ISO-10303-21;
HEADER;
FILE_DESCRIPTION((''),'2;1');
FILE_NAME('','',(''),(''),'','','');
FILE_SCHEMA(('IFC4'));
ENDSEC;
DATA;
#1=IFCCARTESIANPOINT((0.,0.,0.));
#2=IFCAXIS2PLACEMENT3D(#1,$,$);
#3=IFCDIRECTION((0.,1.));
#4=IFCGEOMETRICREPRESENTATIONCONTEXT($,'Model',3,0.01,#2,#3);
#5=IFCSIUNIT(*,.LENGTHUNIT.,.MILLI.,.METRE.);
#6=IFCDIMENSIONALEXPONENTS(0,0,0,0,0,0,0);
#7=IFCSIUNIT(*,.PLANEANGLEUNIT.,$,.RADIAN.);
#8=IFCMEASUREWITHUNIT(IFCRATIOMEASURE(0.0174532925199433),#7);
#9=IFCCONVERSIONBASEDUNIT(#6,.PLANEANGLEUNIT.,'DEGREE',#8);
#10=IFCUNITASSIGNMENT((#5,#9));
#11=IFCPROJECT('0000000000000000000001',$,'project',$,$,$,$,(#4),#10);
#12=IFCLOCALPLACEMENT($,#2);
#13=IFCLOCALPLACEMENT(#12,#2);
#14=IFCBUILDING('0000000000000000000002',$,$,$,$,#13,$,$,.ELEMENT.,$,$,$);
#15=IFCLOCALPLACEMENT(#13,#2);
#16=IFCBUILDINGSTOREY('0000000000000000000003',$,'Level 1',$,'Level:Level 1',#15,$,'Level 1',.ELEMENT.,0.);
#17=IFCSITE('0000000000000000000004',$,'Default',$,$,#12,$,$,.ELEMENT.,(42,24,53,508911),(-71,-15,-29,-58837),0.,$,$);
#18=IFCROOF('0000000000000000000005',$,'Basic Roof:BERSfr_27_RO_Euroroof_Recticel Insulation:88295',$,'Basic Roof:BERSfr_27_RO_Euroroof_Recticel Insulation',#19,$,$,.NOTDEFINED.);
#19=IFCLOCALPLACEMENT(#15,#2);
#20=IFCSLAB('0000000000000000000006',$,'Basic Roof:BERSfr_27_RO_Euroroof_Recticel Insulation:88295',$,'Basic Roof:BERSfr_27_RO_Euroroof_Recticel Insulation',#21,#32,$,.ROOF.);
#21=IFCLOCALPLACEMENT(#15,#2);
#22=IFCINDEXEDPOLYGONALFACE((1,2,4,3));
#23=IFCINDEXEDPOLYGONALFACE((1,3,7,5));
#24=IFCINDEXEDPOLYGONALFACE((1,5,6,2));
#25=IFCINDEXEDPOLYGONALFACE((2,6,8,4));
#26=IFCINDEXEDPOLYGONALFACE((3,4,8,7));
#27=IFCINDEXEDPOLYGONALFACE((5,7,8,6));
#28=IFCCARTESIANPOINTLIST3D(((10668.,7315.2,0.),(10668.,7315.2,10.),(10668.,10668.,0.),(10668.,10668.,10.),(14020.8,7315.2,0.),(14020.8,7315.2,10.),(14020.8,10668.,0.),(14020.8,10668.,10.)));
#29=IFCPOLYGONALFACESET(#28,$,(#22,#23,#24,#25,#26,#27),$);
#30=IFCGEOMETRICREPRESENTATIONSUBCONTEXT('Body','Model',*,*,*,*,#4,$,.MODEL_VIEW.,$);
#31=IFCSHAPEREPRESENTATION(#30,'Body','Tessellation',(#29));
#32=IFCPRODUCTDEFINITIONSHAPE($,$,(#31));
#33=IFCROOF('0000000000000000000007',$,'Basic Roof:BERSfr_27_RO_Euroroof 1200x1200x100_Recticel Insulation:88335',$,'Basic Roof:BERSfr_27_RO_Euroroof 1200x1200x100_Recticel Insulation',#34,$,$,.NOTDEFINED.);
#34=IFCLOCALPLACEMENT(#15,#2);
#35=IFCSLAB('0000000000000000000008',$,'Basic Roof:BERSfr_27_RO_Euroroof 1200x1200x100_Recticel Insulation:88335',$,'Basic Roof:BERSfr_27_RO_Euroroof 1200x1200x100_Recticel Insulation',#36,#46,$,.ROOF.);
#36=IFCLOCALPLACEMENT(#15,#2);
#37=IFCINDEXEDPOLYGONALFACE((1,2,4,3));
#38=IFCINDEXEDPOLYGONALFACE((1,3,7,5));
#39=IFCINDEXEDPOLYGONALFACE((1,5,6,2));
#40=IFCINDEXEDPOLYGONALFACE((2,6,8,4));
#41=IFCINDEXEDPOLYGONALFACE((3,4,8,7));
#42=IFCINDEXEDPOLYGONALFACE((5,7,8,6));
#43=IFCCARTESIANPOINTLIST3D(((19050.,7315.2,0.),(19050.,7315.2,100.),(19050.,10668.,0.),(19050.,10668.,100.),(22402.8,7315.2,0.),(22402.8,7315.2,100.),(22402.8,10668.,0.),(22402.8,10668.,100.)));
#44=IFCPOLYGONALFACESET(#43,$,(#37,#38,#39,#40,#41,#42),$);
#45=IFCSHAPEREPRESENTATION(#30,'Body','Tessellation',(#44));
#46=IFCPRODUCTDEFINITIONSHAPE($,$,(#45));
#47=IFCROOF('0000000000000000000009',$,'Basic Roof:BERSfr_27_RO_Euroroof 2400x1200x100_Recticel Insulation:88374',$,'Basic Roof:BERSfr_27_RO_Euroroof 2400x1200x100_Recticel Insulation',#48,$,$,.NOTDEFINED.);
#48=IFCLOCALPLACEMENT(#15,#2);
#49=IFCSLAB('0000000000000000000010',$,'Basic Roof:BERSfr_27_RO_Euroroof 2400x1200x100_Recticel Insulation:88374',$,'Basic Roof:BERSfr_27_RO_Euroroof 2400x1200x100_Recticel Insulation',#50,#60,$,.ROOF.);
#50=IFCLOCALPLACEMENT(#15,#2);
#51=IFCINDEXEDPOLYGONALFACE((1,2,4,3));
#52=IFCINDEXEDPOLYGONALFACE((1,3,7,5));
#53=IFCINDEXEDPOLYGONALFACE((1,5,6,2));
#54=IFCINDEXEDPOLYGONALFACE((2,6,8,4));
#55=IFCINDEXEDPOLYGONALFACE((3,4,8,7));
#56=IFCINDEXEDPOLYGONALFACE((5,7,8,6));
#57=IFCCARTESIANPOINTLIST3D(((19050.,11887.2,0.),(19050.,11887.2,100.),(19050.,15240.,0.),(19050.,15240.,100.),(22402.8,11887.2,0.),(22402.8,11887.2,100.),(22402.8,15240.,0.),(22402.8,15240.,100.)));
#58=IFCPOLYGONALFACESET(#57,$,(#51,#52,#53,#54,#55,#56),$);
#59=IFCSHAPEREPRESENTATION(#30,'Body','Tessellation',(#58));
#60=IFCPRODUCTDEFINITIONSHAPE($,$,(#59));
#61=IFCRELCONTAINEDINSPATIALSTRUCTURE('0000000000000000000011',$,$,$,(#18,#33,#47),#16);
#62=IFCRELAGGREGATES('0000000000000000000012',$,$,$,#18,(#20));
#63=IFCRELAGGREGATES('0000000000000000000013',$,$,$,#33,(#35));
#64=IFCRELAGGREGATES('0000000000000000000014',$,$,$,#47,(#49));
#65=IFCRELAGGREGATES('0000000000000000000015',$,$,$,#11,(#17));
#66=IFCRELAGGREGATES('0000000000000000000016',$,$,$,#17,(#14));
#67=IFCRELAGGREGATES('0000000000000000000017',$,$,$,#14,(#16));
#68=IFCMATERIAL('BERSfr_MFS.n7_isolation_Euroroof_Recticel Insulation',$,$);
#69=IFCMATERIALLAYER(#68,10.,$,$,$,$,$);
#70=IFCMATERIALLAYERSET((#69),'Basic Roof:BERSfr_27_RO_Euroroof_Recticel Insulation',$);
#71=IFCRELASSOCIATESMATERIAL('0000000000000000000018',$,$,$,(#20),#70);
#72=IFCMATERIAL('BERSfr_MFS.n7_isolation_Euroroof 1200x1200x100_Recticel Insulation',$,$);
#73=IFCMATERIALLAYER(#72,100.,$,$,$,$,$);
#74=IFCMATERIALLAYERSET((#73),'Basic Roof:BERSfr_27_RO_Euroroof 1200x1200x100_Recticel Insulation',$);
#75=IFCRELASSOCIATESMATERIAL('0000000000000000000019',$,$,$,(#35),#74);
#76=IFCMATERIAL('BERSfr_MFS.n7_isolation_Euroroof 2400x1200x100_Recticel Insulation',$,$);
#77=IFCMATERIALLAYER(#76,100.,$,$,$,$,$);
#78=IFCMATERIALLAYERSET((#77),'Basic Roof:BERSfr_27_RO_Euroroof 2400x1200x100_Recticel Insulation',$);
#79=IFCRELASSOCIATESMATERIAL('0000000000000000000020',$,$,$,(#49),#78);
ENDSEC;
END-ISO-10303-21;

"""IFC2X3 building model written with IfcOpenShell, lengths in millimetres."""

from ifc_helpers import new_model, entity, si_unit, converted_unit, direction, frame, frame_2d, origin, place, context, subcontext, project, spatial, rectangle, extrude, material, layer, layer_set, element, aggregate, save


model = new_model("IFC2X3")

# Units and contexts
model_context = context("Model", 3, precision=0.01, world=origin(), true_north=direction((0.0, 1.0)))
body_context = subcontext(model_context, "Body", "Model", "MODEL_VIEW")
ifc_project = project(units=[si_unit("LENGTHUNIT", "METRE", prefix="MILLI"), converted_unit("PLANEANGLEUNIT", "DEGREE", entity("IfcRatioMeasure", 0.0174532925199433), si_unit("PLANEANGLEUNIT", "RADIAN"), dimensions=[0, 0, 0, 0, 0, 0, 0])], contexts=[model_context])

# Site, building, storey
site_placement = place(None, origin())
site = spatial("IfcSite", under=ifc_project, at=site_placement, Name="Default", CompositionType="ELEMENT", RefLatitude=(42, 24, 53, 508911), RefLongitude=(-71, -15, -29, -58837), RefElevation=0.0)
building_placement = place(site_placement, origin())
building = spatial("IfcBuilding", under=site, at=building_placement, CompositionType="ELEMENT")
storey_placement = place(building_placement, origin())
storey = spatial("IfcBuildingStorey", under=building, at=storey_placement, Name="Level 1", ObjectType="Level:Level 1", LongName="Level 1", CompositionType="ELEMENT", Elevation=0.0)

# Roofs, slabs
roof_1_placement = place(storey_placement, frame((10668.0, 7315.2, 0.0)))
roof_1 = element("IfcRoof", 1, at=roof_1_placement, inside=storey, Name="Basic Roof:BERSfr_27_RO_Euroroof_Recticel Insulation:88295", ObjectType="Basic Roof:BERSfr_27_RO_Euroroof_Recticel Insulation", ShapeType="NOTDEFINED")
ifc_material_1 = material(Name="BERSfr_MFS.n7_isolation_Euroroof_Recticel Insulation")
ifc_layer_1 = layer(ifc_material_1, 10.0)
ifc_layer_set_1 = layer_set([ifc_layer_1], Name="Basic Roof:BERSfr_27_RO_Euroroof_Recticel Insulation")
slab_1_placement = place(roof_1_placement, origin())
slab_1 = element("IfcSlab", 2, at=slab_1_placement, material=ifc_layer_set_1, Name="Basic Roof:BERSfr_27_RO_Euroroof_Recticel Insulation:88295", ObjectType="Basic Roof:BERSfr_27_RO_Euroroof_Recticel Insulation", PredefinedType="ROOF", context=body_context, shape_type="SweptSolid", body=[
    extrude(rectangle(XDim=3352.8, YDim=3352.8, at=frame_2d((0.0, 0.0), x_axis=(-1.0, 0.0))), frame((1676.4, 1676.4, 0.0)), (0.0, 0.0, 1.0), 10.0),
])
aggregate(roof_1, [slab_1])
roof_2_placement = place(storey_placement, frame((19050.0, 7315.2, 0.0)))
roof_2 = element("IfcRoof", 3, at=roof_2_placement, inside=storey, Name="Basic Roof:BERSfr_27_RO_Euroroof 1200x1200x100_Recticel Insulation:88335", ObjectType="Basic Roof:BERSfr_27_RO_Euroroof 1200x1200x100_Recticel Insulation", ShapeType="NOTDEFINED")
ifc_material_2 = material(Name="BERSfr_MFS.n7_isolation_Euroroof 1200x1200x100_Recticel Insulation")
ifc_layer_2 = layer(ifc_material_2, 100.0)
ifc_layer_set_2 = layer_set([ifc_layer_2], Name="Basic Roof:BERSfr_27_RO_Euroroof 1200x1200x100_Recticel Insulation")
slab_2_placement = place(roof_2_placement, origin())
slab_2 = element("IfcSlab", 4, at=slab_2_placement, material=ifc_layer_set_2, Name="Basic Roof:BERSfr_27_RO_Euroroof 1200x1200x100_Recticel Insulation:88335", ObjectType="Basic Roof:BERSfr_27_RO_Euroroof 1200x1200x100_Recticel Insulation", PredefinedType="ROOF", context=body_context, shape_type="SweptSolid", body=[
    extrude(rectangle(XDim=3352.8, YDim=3352.8, at=frame_2d((0.0, 0.0), x_axis=(-1.0, 0.0))), frame((1676.4, 1676.4, 0.0)), (0.0, 0.0, 1.0), 100.0),
])
aggregate(roof_2, [slab_2])
roof_3_placement = place(storey_placement, frame((19050.0, 11887.2, 0.0)))
roof_3 = element("IfcRoof", 5, at=roof_3_placement, inside=storey, Name="Basic Roof:BERSfr_27_RO_Euroroof 2400x1200x100_Recticel Insulation:88374", ObjectType="Basic Roof:BERSfr_27_RO_Euroroof 2400x1200x100_Recticel Insulation", ShapeType="NOTDEFINED")
ifc_material_3 = material(Name="BERSfr_MFS.n7_isolation_Euroroof 2400x1200x100_Recticel Insulation")
ifc_layer_3 = layer(ifc_material_3, 100.0)
ifc_layer_set_3 = layer_set([ifc_layer_3], Name="Basic Roof:BERSfr_27_RO_Euroroof 2400x1200x100_Recticel Insulation")
slab_3_placement = place(roof_3_placement, origin())
slab_3 = element("IfcSlab", 6, at=slab_3_placement, material=ifc_layer_set_3, Name="Basic Roof:BERSfr_27_RO_Euroroof 2400x1200x100_Recticel Insulation:88374", ObjectType="Basic Roof:BERSfr_27_RO_Euroroof 2400x1200x100_Recticel Insulation", PredefinedType="ROOF", context=body_context, shape_type="SweptSolid", body=[
    extrude(rectangle(XDim=3352.8, YDim=3352.8, at=frame_2d((0.0, 0.0), x_axis=(-1.0, 0.0))), frame((1676.4, 1676.4, 0.0)), (0.0, 0.0, 1.0), 100.0),
])
aggregate(roof_3, [slab_3])

save(model, "model.ifc")
